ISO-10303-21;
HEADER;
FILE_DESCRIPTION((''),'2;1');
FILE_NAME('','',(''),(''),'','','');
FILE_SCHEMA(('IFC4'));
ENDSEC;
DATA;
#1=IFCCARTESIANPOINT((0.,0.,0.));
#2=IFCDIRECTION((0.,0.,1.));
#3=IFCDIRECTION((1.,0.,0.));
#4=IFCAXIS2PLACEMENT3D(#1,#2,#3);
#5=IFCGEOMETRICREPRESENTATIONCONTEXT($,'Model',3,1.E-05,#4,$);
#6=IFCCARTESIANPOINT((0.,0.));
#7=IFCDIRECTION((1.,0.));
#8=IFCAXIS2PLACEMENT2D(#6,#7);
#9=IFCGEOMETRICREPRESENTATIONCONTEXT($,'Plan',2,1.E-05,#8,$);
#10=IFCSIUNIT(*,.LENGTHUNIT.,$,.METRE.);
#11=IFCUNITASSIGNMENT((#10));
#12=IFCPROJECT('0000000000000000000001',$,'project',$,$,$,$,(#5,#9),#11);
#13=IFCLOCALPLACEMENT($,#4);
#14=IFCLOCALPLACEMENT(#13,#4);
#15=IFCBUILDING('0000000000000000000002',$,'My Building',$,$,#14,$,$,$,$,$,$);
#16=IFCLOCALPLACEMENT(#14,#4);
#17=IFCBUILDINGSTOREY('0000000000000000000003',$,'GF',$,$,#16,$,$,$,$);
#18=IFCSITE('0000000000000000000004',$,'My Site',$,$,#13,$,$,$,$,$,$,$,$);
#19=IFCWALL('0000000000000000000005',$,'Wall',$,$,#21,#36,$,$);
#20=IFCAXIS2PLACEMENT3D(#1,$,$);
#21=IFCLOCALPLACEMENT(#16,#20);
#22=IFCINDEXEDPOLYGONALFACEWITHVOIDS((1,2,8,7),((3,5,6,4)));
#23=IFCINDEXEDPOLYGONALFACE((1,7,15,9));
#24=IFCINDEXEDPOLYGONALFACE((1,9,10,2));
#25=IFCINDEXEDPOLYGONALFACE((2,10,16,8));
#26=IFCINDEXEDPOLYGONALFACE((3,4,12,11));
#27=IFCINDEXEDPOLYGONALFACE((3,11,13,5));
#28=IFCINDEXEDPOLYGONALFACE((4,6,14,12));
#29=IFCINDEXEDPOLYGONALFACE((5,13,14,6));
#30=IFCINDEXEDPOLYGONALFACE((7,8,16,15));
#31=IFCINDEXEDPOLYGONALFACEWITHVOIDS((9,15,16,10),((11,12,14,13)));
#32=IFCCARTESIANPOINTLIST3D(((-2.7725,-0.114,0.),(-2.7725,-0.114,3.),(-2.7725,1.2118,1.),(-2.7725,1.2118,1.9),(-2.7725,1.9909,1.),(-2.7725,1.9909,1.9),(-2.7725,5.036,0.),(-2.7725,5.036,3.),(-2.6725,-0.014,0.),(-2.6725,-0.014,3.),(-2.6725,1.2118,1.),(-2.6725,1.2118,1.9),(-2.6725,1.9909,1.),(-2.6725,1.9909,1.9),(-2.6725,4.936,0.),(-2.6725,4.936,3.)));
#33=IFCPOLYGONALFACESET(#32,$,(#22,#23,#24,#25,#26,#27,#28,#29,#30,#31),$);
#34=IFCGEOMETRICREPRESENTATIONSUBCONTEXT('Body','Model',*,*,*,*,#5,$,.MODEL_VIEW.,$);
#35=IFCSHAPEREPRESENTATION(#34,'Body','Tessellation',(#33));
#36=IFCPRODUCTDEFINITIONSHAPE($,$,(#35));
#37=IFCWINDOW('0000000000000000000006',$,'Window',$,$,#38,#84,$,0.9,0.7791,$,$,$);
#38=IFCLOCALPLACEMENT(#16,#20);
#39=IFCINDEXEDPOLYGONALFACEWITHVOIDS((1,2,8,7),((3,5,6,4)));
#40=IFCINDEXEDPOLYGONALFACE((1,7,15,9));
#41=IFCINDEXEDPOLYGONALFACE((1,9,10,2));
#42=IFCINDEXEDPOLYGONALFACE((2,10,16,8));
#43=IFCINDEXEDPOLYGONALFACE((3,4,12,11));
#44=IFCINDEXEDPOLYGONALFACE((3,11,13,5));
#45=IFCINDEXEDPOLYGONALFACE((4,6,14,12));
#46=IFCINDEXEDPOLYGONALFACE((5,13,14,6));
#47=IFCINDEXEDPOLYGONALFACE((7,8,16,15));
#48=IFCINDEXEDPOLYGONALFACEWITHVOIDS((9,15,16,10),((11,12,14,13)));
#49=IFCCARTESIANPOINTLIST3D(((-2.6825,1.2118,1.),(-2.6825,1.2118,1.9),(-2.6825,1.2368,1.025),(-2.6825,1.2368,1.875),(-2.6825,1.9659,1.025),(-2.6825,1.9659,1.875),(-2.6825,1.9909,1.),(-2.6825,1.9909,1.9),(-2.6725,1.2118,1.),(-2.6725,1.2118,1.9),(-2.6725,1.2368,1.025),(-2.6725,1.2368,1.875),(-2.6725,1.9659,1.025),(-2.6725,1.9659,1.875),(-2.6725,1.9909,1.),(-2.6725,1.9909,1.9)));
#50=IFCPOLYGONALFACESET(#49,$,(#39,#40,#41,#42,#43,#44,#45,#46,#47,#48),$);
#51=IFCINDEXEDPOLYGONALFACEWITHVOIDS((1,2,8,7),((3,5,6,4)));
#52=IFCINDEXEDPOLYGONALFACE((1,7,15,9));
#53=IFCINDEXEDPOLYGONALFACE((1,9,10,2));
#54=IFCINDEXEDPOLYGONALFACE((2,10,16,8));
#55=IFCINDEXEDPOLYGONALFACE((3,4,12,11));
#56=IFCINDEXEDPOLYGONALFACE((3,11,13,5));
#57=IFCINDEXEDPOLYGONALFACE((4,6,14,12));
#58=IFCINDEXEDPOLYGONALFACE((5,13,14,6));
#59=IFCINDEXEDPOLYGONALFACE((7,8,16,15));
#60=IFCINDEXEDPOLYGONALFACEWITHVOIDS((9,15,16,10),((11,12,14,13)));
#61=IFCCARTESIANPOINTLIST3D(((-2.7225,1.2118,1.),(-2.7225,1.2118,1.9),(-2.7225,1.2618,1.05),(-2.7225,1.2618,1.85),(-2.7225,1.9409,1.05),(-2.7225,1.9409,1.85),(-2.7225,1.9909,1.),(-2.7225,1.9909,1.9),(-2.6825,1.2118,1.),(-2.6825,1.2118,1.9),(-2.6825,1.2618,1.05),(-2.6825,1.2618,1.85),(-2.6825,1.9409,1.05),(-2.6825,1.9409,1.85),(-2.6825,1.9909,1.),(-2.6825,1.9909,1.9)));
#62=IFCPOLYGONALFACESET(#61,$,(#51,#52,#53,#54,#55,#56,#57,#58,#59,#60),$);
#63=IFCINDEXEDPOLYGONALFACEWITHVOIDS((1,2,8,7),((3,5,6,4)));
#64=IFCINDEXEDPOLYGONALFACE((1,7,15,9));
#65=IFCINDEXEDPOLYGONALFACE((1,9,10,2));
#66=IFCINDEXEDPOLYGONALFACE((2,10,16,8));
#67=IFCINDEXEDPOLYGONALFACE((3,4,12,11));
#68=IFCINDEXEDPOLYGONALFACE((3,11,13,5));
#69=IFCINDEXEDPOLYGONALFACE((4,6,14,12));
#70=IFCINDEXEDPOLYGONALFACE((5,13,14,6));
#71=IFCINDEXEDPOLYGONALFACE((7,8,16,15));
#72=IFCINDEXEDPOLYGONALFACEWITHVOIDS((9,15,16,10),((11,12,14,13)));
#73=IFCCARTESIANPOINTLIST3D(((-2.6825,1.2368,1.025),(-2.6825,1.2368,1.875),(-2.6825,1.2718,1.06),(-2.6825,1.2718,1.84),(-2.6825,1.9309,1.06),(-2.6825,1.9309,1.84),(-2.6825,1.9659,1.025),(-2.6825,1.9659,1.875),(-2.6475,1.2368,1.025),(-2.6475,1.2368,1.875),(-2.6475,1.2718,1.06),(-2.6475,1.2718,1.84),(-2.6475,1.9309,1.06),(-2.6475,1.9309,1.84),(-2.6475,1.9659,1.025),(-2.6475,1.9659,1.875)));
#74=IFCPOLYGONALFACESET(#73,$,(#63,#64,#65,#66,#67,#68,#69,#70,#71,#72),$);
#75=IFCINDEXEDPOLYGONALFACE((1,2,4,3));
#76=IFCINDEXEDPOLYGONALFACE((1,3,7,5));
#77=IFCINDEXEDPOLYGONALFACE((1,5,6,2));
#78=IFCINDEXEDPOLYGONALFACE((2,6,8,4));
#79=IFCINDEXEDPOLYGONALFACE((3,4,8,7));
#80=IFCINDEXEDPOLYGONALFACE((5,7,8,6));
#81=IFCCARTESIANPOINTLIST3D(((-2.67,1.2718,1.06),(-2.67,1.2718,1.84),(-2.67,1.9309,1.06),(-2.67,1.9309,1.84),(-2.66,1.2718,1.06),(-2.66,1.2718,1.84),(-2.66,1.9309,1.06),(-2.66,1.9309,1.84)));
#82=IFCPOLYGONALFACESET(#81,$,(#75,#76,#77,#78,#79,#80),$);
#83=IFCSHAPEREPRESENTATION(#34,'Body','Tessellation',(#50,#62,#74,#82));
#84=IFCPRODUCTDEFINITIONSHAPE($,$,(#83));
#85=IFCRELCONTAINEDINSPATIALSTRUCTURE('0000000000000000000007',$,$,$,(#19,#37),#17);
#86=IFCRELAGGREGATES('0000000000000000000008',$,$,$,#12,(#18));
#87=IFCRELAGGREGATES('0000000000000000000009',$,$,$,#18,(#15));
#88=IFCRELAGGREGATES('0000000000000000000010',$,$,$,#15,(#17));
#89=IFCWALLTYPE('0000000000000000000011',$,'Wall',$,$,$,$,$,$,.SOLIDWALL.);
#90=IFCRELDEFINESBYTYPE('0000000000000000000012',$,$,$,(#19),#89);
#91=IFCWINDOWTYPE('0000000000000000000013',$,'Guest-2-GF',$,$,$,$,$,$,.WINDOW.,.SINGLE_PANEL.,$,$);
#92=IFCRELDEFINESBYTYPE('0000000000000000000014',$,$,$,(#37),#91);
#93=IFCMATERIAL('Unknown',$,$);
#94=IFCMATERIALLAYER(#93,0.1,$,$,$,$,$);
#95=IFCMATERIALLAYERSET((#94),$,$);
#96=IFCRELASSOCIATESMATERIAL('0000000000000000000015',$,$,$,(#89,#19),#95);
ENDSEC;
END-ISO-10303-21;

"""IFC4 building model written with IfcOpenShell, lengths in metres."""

from ifc_helpers import new_model, entity, si_unit, frame, origin_with_axes, origin_2d_with_axis, place, context, subcontext, project, spatial, line, indexed_curve, outline, extrude, shape, source, transform, mapped, material, layer, layer_set, layer_usage, type_object, type_shapes, element, fill, save


model = new_model("IFC4")

# Units and contexts
model_context = context("Model", 3, precision=1e-05, world=origin_with_axes())
plan_context = context("Plan", 2, precision=1e-05, world=origin_2d_with_axis())
body_context_1 = subcontext(model_context, "Body", "Model", "MODEL_VIEW")
body_context_2 = subcontext(plan_context, "Body", "Plan", "PLAN_VIEW")
ifc_project = project(units=[si_unit("LENGTHUNIT", "METRE")], contexts=[model_context, plan_context])

# Site, building, storey
site_placement = place(None, origin_with_axes())
site = spatial("IfcSite", under=ifc_project, at=site_placement, Name="My Site")
building_placement = place(site_placement, origin_with_axes())
building = spatial("IfcBuilding", under=site, at=building_placement, Name="My Building")
storey_placement = place(building_placement, origin_with_axes())
storey = spatial("IfcBuildingStorey", under=building, at=storey_placement, Name="GF")

# Shared definitions
ifc_material = material(Name="Unknown")

# Shared definitions
ifc_layer_1 = layer(ifc_material, 0.1)
ifc_layer_set_1 = layer_set([ifc_layer_1])
wall_type = type_object("IfcWallType", Name="Wall", PredefinedType="SOLIDWALL", material=ifc_layer_set_1)

# Wall, opening, window
ifc_layer_usage_1 = layer_usage(ifc_layer_set_1, "AXIS2", "POSITIVE", 0.0)
wall_1_placement = place(storey_placement, frame((-2.7725, 5.036, 0.0), z_axis=(0.0, 0.0, 1.0), x_axis=(0.0, -1.0, 0.0)))
wall_1 = element("IfcWall", 1, at=wall_1_placement, inside=storey, type_object=wall_type, material=ifc_layer_usage_1, Name="Wall", context=body_context_1, shape_type="SweptSolid", body=[
    extrude(outline(indexed_curve([(0.0, 0.0), (0.1, 0.1), (5.05, 0.1), (5.15, 0.0)], segments=[line(1, 2, 3, 4, 1)])), origin_with_axes(), (0.0, 0.0, 1.0), 3.0),
])
shared_shape_1 = source(origin_with_axes(), body_context_1, "Body", "SweptSolid", [
    extrude(outline(indexed_curve([(0.0, 0.0), (0.7791, 0.0), (0.7791, 0.9), (0.0, 0.9)], segments=[line(1, 2, 3, 4, 1)])), frame((0.0, -0.6, 0.0), z_axis=(0.0, -1.0, 0.0), x_axis=(1.0, 0.0, 0.0)), (0.0, 0.0, -1.0), 1.2),
])
opening_1_placement = place(wall_1_placement, frame((3.0451, 0.0, 1.0), z_axis=(0.0, 0.0, 1.0), x_axis=(1.0, 0.0, 0.0)))
opening_1 = element("IfcOpeningElement", 2, at=opening_1_placement, cuts=wall_1, PredefinedType="OPENING", context=body_context_1, shape_type="MappedRepresentation", body=[
    mapped(shared_shape_1, transform((0.0, 0.0, 0.0), x_axis=(1.0, 0.0, 0.0), y_axis=(0.0, 1.0, 0.0), z_axis=(0.0, 0.0, 1.0), scale=1.0)),
])
window_type_1 = type_object("IfcWindowType", Name="Guest-2-GF", PartitioningType="SINGLE_PANEL", PredefinedType="WINDOW")
shared_shape_2 = source(origin_with_axes(), body_context_1, "Body", "SweptSolid", [
    extrude(outline(indexed_curve([(0.0, 0.0), (0.7791, 0.0), (0.7791, 0.9), (0.0, 0.9)], segments=[line(1, 2, 3, 4, 1)]), holes=[indexed_curve([(0.025, 0.025), (0.7541, 0.025), (0.7541, 0.875), (0.025, 0.875)], segments=[line(1, 2, 3, 4, 1)])]), frame((0.0, 0.09, 0.0), z_axis=(0.0, -1.0, 0.0), x_axis=(1.0, 0.0, 0.0)), (0.0, 0.0, -1.0), 0.01),
    extrude(outline(indexed_curve([(0.0, 0.0), (0.7791, 0.0), (0.7791, 0.9), (0.0, 0.9)], segments=[line(1, 2, 3, 4, 1)]), holes=[indexed_curve([(0.05, 0.05), (0.7291, 0.05), (0.7291, 0.85), (0.05, 0.85)], segments=[line(1, 2, 3, 4, 1)])]), frame((0.0, 0.05, 0.0), z_axis=(0.0, -1.0, 0.0), x_axis=(1.0, 0.0, 0.0)), (0.0, 0.0, -1.0), 0.04),
    extrude(outline(indexed_curve([(0.0, 0.0), (0.7291, 0.0), (0.7291, 0.85), (0.0, 0.85)], segments=[line(1, 2, 3, 4, 1)]), holes=[indexed_curve([(0.035, 0.035), (0.6941, 0.035), (0.6941, 0.815), (0.035, 0.815)], segments=[line(1, 2, 3, 4, 1)])]), frame((0.025, 0.09, 0.025), z_axis=(0.0, -1.0, 0.0), x_axis=(1.0, 0.0, 0.0)), (0.0, 0.0, -1.0), 0.035),
    extrude(outline(indexed_curve([(0.035, 0.035), (0.6941, 0.035), (0.6941, 0.815), (0.035, 0.815)], segments=[line(1, 2, 3, 4, 1)])), frame((0.025, 0.1025, 0.025), z_axis=(0.0, -1.0, 0.0), x_axis=(1.0, 0.0, 0.0)), (0.0, 0.0, -1.0), 0.01),
])
shared_shape_3 = source(origin_with_axes(), body_context_2, "Body", "Curve2D", [
    entity("IfcIndexedPolyCurve", entity("IfcCartesianPointList2D", [[0.05, 0.05], [0.7291, 0.05]])),
    entity("IfcIndexedPolyCurve", entity("IfcCartesianPointList2D", [[0.0, 0.1], [0.025, 0.1], [0.025, 0.09], [0.05, 0.09], [0.05, 0.05], [0.0, 0.05]]), [entity("IfcLineIndex", [1, 2, 3, 4, 5, 6, 1])]),
    entity("IfcIndexedPolyCurve", entity("IfcCartesianPointList2D", [[0.7791, 0.1], [0.7541, 0.1], [0.7541, 0.09], [0.7291, 0.09], [0.7291, 0.05], [0.7791, 0.05]]), [entity("IfcLineIndex", [1, 2, 3, 4, 5, 6, 1])]),
    entity("IfcIndexedPolyCurve", entity("IfcCartesianPointList2D", [[0.025, 0.09], [0.06, 0.09], [0.06, 0.125], [0.025, 0.125]]), [entity("IfcLineIndex", [1, 2, 3, 4, 1])]),
    entity("IfcIndexedPolyCurve", entity("IfcCartesianPointList2D", [[0.7541, 0.09], [0.7191, 0.09], [0.7191, 0.125], [0.7541, 0.125]]), [entity("IfcLineIndex", [1, 2, 3, 4, 1])]),
    entity("IfcIndexedPolyCurve", entity("IfcCartesianPointList2D", [[0.06, 0.09], [0.7191, 0.09]])),
    entity("IfcIndexedPolyCurve", entity("IfcCartesianPointList2D", [[0.06, 0.125], [0.7191, 0.125]])),
    entity("IfcIndexedPolyCurve", entity("IfcCartesianPointList2D", [[0.06, 0.1075], [0.7191, 0.1075]])),
])
type_shapes(window_type_1, [shared_shape_2, shared_shape_3])
window_1_placement = place(opening_1_placement, frame((0.0, 0.0, 0.0), z_axis=(0.0, 0.0, 1.0), x_axis=(1.0, 0.0, 0.0)))
window_1 = element("IfcWindow", 3, at=window_1_placement, inside=storey, type_object=window_type_1, Name="Window", OverallHeight=0.9, OverallWidth=0.7791, shapes=[
    shape(body_context_1, "Body", "MappedRepresentation", [mapped(shared_shape_2, transform((0.0, 0.0, 0.0), x_axis=(1.0, 0.0, 0.0), y_axis=(0.0, 1.0, 0.0), z_axis=(0.0, 0.0, 1.0), scale=1.0))]),
    shape(body_context_2, "Body", "MappedRepresentation", [mapped(shared_shape_3, transform((0.0, 0.0, 0.0), x_axis=(1.0, 0.0, 0.0), y_axis=(0.0, 1.0, 0.0), z_axis=(0.0, 0.0, 1.0), scale=1.0))]),
])
fill(opening_1, window_1)

save(model, "model.ifc")
